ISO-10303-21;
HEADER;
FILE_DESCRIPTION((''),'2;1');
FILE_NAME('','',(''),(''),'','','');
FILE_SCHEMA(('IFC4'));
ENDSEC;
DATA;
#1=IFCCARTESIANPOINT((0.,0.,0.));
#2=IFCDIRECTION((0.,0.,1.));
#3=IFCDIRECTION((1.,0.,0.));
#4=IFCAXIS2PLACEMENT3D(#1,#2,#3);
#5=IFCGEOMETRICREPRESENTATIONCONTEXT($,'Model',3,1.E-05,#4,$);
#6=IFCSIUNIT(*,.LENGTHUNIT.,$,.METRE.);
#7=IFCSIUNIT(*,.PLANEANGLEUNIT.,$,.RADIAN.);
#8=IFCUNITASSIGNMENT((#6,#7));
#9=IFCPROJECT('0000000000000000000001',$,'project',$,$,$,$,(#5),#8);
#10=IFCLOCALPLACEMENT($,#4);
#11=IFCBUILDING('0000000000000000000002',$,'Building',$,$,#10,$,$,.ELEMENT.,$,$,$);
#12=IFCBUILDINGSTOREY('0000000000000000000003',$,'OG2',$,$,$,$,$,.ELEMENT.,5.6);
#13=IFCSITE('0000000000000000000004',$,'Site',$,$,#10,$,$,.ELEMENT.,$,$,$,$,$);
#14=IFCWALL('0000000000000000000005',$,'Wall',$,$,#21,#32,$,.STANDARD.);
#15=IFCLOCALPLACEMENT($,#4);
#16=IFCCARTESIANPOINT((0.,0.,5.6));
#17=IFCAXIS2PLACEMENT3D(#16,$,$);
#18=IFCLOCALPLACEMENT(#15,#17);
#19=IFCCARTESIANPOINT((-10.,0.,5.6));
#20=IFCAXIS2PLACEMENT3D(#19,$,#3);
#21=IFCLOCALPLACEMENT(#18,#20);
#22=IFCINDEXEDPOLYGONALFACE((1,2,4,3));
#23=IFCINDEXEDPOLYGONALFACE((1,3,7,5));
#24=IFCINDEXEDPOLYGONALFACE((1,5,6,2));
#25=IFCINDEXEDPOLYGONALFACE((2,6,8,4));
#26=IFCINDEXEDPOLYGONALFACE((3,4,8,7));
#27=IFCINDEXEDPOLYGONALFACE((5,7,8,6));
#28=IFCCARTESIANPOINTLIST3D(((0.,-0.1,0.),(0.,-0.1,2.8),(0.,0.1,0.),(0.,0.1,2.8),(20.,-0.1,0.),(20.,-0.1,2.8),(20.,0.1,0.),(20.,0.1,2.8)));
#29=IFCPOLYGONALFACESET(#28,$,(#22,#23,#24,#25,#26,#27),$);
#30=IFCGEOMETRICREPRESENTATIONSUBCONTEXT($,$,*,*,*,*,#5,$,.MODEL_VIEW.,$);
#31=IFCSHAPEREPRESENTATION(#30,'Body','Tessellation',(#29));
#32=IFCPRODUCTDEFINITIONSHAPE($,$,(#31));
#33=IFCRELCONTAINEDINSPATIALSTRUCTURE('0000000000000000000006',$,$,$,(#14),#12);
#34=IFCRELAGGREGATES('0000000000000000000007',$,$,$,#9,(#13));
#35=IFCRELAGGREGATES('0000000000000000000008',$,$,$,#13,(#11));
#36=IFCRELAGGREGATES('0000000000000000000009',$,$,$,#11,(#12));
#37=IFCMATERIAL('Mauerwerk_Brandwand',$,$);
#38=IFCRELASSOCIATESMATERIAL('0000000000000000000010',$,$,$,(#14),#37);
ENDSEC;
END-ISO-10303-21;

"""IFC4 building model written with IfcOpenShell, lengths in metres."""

from ifc_helpers import new_model, si_unit, frame, frame_2d, origin, origin_with_axes, place, context, subcontext, project, spatial, rectangle, extrude, material, element, save


model = new_model("IFC4")

# Units and contexts
model_context = context("Model", 3, precision=1e-05, world=origin_with_axes())
sub_context = subcontext(model_context, None, None, "MODEL_VIEW")
ifc_project = project(units=[si_unit("LENGTHUNIT", "METRE"), si_unit("PLANEANGLEUNIT", "RADIAN")], contexts=[model_context])

# Site, building, storey
placement_1 = place(None, origin_with_axes())
site = spatial("IfcSite", under=ifc_project, at=placement_1, Name="Site", CompositionType="ELEMENT")
building = spatial("IfcBuilding", under=site, at=placement_1, Name="Building", CompositionType="ELEMENT")
storey = spatial("IfcBuildingStorey", under=building, Name="OG2", CompositionType="ELEMENT", Elevation=5.6)

# Wall
ifc_material = material(Name="Mauerwerk_Brandwand")
placement_2 = place(None, origin_with_axes())
placement_3 = place(placement_2, frame((0.0, 0.0, 5.6)))
wall_placement = place(placement_3, frame((-10.0, 0.0, 5.6), x_axis=(1.0, 0.0, 0.0)))
element("IfcWall", 1, at=wall_placement, inside=storey, material=ifc_material, Name="Wall", PredefinedType="STANDARD", context=sub_context, shape_type="SweptSolid", body=[
    extrude(rectangle(XDim=20.0, YDim=0.2, at=frame_2d((10.0, 0.0))), origin(), (0.0, 0.0, 1.0), 2.8),
])

save(model, "model.ifc")
